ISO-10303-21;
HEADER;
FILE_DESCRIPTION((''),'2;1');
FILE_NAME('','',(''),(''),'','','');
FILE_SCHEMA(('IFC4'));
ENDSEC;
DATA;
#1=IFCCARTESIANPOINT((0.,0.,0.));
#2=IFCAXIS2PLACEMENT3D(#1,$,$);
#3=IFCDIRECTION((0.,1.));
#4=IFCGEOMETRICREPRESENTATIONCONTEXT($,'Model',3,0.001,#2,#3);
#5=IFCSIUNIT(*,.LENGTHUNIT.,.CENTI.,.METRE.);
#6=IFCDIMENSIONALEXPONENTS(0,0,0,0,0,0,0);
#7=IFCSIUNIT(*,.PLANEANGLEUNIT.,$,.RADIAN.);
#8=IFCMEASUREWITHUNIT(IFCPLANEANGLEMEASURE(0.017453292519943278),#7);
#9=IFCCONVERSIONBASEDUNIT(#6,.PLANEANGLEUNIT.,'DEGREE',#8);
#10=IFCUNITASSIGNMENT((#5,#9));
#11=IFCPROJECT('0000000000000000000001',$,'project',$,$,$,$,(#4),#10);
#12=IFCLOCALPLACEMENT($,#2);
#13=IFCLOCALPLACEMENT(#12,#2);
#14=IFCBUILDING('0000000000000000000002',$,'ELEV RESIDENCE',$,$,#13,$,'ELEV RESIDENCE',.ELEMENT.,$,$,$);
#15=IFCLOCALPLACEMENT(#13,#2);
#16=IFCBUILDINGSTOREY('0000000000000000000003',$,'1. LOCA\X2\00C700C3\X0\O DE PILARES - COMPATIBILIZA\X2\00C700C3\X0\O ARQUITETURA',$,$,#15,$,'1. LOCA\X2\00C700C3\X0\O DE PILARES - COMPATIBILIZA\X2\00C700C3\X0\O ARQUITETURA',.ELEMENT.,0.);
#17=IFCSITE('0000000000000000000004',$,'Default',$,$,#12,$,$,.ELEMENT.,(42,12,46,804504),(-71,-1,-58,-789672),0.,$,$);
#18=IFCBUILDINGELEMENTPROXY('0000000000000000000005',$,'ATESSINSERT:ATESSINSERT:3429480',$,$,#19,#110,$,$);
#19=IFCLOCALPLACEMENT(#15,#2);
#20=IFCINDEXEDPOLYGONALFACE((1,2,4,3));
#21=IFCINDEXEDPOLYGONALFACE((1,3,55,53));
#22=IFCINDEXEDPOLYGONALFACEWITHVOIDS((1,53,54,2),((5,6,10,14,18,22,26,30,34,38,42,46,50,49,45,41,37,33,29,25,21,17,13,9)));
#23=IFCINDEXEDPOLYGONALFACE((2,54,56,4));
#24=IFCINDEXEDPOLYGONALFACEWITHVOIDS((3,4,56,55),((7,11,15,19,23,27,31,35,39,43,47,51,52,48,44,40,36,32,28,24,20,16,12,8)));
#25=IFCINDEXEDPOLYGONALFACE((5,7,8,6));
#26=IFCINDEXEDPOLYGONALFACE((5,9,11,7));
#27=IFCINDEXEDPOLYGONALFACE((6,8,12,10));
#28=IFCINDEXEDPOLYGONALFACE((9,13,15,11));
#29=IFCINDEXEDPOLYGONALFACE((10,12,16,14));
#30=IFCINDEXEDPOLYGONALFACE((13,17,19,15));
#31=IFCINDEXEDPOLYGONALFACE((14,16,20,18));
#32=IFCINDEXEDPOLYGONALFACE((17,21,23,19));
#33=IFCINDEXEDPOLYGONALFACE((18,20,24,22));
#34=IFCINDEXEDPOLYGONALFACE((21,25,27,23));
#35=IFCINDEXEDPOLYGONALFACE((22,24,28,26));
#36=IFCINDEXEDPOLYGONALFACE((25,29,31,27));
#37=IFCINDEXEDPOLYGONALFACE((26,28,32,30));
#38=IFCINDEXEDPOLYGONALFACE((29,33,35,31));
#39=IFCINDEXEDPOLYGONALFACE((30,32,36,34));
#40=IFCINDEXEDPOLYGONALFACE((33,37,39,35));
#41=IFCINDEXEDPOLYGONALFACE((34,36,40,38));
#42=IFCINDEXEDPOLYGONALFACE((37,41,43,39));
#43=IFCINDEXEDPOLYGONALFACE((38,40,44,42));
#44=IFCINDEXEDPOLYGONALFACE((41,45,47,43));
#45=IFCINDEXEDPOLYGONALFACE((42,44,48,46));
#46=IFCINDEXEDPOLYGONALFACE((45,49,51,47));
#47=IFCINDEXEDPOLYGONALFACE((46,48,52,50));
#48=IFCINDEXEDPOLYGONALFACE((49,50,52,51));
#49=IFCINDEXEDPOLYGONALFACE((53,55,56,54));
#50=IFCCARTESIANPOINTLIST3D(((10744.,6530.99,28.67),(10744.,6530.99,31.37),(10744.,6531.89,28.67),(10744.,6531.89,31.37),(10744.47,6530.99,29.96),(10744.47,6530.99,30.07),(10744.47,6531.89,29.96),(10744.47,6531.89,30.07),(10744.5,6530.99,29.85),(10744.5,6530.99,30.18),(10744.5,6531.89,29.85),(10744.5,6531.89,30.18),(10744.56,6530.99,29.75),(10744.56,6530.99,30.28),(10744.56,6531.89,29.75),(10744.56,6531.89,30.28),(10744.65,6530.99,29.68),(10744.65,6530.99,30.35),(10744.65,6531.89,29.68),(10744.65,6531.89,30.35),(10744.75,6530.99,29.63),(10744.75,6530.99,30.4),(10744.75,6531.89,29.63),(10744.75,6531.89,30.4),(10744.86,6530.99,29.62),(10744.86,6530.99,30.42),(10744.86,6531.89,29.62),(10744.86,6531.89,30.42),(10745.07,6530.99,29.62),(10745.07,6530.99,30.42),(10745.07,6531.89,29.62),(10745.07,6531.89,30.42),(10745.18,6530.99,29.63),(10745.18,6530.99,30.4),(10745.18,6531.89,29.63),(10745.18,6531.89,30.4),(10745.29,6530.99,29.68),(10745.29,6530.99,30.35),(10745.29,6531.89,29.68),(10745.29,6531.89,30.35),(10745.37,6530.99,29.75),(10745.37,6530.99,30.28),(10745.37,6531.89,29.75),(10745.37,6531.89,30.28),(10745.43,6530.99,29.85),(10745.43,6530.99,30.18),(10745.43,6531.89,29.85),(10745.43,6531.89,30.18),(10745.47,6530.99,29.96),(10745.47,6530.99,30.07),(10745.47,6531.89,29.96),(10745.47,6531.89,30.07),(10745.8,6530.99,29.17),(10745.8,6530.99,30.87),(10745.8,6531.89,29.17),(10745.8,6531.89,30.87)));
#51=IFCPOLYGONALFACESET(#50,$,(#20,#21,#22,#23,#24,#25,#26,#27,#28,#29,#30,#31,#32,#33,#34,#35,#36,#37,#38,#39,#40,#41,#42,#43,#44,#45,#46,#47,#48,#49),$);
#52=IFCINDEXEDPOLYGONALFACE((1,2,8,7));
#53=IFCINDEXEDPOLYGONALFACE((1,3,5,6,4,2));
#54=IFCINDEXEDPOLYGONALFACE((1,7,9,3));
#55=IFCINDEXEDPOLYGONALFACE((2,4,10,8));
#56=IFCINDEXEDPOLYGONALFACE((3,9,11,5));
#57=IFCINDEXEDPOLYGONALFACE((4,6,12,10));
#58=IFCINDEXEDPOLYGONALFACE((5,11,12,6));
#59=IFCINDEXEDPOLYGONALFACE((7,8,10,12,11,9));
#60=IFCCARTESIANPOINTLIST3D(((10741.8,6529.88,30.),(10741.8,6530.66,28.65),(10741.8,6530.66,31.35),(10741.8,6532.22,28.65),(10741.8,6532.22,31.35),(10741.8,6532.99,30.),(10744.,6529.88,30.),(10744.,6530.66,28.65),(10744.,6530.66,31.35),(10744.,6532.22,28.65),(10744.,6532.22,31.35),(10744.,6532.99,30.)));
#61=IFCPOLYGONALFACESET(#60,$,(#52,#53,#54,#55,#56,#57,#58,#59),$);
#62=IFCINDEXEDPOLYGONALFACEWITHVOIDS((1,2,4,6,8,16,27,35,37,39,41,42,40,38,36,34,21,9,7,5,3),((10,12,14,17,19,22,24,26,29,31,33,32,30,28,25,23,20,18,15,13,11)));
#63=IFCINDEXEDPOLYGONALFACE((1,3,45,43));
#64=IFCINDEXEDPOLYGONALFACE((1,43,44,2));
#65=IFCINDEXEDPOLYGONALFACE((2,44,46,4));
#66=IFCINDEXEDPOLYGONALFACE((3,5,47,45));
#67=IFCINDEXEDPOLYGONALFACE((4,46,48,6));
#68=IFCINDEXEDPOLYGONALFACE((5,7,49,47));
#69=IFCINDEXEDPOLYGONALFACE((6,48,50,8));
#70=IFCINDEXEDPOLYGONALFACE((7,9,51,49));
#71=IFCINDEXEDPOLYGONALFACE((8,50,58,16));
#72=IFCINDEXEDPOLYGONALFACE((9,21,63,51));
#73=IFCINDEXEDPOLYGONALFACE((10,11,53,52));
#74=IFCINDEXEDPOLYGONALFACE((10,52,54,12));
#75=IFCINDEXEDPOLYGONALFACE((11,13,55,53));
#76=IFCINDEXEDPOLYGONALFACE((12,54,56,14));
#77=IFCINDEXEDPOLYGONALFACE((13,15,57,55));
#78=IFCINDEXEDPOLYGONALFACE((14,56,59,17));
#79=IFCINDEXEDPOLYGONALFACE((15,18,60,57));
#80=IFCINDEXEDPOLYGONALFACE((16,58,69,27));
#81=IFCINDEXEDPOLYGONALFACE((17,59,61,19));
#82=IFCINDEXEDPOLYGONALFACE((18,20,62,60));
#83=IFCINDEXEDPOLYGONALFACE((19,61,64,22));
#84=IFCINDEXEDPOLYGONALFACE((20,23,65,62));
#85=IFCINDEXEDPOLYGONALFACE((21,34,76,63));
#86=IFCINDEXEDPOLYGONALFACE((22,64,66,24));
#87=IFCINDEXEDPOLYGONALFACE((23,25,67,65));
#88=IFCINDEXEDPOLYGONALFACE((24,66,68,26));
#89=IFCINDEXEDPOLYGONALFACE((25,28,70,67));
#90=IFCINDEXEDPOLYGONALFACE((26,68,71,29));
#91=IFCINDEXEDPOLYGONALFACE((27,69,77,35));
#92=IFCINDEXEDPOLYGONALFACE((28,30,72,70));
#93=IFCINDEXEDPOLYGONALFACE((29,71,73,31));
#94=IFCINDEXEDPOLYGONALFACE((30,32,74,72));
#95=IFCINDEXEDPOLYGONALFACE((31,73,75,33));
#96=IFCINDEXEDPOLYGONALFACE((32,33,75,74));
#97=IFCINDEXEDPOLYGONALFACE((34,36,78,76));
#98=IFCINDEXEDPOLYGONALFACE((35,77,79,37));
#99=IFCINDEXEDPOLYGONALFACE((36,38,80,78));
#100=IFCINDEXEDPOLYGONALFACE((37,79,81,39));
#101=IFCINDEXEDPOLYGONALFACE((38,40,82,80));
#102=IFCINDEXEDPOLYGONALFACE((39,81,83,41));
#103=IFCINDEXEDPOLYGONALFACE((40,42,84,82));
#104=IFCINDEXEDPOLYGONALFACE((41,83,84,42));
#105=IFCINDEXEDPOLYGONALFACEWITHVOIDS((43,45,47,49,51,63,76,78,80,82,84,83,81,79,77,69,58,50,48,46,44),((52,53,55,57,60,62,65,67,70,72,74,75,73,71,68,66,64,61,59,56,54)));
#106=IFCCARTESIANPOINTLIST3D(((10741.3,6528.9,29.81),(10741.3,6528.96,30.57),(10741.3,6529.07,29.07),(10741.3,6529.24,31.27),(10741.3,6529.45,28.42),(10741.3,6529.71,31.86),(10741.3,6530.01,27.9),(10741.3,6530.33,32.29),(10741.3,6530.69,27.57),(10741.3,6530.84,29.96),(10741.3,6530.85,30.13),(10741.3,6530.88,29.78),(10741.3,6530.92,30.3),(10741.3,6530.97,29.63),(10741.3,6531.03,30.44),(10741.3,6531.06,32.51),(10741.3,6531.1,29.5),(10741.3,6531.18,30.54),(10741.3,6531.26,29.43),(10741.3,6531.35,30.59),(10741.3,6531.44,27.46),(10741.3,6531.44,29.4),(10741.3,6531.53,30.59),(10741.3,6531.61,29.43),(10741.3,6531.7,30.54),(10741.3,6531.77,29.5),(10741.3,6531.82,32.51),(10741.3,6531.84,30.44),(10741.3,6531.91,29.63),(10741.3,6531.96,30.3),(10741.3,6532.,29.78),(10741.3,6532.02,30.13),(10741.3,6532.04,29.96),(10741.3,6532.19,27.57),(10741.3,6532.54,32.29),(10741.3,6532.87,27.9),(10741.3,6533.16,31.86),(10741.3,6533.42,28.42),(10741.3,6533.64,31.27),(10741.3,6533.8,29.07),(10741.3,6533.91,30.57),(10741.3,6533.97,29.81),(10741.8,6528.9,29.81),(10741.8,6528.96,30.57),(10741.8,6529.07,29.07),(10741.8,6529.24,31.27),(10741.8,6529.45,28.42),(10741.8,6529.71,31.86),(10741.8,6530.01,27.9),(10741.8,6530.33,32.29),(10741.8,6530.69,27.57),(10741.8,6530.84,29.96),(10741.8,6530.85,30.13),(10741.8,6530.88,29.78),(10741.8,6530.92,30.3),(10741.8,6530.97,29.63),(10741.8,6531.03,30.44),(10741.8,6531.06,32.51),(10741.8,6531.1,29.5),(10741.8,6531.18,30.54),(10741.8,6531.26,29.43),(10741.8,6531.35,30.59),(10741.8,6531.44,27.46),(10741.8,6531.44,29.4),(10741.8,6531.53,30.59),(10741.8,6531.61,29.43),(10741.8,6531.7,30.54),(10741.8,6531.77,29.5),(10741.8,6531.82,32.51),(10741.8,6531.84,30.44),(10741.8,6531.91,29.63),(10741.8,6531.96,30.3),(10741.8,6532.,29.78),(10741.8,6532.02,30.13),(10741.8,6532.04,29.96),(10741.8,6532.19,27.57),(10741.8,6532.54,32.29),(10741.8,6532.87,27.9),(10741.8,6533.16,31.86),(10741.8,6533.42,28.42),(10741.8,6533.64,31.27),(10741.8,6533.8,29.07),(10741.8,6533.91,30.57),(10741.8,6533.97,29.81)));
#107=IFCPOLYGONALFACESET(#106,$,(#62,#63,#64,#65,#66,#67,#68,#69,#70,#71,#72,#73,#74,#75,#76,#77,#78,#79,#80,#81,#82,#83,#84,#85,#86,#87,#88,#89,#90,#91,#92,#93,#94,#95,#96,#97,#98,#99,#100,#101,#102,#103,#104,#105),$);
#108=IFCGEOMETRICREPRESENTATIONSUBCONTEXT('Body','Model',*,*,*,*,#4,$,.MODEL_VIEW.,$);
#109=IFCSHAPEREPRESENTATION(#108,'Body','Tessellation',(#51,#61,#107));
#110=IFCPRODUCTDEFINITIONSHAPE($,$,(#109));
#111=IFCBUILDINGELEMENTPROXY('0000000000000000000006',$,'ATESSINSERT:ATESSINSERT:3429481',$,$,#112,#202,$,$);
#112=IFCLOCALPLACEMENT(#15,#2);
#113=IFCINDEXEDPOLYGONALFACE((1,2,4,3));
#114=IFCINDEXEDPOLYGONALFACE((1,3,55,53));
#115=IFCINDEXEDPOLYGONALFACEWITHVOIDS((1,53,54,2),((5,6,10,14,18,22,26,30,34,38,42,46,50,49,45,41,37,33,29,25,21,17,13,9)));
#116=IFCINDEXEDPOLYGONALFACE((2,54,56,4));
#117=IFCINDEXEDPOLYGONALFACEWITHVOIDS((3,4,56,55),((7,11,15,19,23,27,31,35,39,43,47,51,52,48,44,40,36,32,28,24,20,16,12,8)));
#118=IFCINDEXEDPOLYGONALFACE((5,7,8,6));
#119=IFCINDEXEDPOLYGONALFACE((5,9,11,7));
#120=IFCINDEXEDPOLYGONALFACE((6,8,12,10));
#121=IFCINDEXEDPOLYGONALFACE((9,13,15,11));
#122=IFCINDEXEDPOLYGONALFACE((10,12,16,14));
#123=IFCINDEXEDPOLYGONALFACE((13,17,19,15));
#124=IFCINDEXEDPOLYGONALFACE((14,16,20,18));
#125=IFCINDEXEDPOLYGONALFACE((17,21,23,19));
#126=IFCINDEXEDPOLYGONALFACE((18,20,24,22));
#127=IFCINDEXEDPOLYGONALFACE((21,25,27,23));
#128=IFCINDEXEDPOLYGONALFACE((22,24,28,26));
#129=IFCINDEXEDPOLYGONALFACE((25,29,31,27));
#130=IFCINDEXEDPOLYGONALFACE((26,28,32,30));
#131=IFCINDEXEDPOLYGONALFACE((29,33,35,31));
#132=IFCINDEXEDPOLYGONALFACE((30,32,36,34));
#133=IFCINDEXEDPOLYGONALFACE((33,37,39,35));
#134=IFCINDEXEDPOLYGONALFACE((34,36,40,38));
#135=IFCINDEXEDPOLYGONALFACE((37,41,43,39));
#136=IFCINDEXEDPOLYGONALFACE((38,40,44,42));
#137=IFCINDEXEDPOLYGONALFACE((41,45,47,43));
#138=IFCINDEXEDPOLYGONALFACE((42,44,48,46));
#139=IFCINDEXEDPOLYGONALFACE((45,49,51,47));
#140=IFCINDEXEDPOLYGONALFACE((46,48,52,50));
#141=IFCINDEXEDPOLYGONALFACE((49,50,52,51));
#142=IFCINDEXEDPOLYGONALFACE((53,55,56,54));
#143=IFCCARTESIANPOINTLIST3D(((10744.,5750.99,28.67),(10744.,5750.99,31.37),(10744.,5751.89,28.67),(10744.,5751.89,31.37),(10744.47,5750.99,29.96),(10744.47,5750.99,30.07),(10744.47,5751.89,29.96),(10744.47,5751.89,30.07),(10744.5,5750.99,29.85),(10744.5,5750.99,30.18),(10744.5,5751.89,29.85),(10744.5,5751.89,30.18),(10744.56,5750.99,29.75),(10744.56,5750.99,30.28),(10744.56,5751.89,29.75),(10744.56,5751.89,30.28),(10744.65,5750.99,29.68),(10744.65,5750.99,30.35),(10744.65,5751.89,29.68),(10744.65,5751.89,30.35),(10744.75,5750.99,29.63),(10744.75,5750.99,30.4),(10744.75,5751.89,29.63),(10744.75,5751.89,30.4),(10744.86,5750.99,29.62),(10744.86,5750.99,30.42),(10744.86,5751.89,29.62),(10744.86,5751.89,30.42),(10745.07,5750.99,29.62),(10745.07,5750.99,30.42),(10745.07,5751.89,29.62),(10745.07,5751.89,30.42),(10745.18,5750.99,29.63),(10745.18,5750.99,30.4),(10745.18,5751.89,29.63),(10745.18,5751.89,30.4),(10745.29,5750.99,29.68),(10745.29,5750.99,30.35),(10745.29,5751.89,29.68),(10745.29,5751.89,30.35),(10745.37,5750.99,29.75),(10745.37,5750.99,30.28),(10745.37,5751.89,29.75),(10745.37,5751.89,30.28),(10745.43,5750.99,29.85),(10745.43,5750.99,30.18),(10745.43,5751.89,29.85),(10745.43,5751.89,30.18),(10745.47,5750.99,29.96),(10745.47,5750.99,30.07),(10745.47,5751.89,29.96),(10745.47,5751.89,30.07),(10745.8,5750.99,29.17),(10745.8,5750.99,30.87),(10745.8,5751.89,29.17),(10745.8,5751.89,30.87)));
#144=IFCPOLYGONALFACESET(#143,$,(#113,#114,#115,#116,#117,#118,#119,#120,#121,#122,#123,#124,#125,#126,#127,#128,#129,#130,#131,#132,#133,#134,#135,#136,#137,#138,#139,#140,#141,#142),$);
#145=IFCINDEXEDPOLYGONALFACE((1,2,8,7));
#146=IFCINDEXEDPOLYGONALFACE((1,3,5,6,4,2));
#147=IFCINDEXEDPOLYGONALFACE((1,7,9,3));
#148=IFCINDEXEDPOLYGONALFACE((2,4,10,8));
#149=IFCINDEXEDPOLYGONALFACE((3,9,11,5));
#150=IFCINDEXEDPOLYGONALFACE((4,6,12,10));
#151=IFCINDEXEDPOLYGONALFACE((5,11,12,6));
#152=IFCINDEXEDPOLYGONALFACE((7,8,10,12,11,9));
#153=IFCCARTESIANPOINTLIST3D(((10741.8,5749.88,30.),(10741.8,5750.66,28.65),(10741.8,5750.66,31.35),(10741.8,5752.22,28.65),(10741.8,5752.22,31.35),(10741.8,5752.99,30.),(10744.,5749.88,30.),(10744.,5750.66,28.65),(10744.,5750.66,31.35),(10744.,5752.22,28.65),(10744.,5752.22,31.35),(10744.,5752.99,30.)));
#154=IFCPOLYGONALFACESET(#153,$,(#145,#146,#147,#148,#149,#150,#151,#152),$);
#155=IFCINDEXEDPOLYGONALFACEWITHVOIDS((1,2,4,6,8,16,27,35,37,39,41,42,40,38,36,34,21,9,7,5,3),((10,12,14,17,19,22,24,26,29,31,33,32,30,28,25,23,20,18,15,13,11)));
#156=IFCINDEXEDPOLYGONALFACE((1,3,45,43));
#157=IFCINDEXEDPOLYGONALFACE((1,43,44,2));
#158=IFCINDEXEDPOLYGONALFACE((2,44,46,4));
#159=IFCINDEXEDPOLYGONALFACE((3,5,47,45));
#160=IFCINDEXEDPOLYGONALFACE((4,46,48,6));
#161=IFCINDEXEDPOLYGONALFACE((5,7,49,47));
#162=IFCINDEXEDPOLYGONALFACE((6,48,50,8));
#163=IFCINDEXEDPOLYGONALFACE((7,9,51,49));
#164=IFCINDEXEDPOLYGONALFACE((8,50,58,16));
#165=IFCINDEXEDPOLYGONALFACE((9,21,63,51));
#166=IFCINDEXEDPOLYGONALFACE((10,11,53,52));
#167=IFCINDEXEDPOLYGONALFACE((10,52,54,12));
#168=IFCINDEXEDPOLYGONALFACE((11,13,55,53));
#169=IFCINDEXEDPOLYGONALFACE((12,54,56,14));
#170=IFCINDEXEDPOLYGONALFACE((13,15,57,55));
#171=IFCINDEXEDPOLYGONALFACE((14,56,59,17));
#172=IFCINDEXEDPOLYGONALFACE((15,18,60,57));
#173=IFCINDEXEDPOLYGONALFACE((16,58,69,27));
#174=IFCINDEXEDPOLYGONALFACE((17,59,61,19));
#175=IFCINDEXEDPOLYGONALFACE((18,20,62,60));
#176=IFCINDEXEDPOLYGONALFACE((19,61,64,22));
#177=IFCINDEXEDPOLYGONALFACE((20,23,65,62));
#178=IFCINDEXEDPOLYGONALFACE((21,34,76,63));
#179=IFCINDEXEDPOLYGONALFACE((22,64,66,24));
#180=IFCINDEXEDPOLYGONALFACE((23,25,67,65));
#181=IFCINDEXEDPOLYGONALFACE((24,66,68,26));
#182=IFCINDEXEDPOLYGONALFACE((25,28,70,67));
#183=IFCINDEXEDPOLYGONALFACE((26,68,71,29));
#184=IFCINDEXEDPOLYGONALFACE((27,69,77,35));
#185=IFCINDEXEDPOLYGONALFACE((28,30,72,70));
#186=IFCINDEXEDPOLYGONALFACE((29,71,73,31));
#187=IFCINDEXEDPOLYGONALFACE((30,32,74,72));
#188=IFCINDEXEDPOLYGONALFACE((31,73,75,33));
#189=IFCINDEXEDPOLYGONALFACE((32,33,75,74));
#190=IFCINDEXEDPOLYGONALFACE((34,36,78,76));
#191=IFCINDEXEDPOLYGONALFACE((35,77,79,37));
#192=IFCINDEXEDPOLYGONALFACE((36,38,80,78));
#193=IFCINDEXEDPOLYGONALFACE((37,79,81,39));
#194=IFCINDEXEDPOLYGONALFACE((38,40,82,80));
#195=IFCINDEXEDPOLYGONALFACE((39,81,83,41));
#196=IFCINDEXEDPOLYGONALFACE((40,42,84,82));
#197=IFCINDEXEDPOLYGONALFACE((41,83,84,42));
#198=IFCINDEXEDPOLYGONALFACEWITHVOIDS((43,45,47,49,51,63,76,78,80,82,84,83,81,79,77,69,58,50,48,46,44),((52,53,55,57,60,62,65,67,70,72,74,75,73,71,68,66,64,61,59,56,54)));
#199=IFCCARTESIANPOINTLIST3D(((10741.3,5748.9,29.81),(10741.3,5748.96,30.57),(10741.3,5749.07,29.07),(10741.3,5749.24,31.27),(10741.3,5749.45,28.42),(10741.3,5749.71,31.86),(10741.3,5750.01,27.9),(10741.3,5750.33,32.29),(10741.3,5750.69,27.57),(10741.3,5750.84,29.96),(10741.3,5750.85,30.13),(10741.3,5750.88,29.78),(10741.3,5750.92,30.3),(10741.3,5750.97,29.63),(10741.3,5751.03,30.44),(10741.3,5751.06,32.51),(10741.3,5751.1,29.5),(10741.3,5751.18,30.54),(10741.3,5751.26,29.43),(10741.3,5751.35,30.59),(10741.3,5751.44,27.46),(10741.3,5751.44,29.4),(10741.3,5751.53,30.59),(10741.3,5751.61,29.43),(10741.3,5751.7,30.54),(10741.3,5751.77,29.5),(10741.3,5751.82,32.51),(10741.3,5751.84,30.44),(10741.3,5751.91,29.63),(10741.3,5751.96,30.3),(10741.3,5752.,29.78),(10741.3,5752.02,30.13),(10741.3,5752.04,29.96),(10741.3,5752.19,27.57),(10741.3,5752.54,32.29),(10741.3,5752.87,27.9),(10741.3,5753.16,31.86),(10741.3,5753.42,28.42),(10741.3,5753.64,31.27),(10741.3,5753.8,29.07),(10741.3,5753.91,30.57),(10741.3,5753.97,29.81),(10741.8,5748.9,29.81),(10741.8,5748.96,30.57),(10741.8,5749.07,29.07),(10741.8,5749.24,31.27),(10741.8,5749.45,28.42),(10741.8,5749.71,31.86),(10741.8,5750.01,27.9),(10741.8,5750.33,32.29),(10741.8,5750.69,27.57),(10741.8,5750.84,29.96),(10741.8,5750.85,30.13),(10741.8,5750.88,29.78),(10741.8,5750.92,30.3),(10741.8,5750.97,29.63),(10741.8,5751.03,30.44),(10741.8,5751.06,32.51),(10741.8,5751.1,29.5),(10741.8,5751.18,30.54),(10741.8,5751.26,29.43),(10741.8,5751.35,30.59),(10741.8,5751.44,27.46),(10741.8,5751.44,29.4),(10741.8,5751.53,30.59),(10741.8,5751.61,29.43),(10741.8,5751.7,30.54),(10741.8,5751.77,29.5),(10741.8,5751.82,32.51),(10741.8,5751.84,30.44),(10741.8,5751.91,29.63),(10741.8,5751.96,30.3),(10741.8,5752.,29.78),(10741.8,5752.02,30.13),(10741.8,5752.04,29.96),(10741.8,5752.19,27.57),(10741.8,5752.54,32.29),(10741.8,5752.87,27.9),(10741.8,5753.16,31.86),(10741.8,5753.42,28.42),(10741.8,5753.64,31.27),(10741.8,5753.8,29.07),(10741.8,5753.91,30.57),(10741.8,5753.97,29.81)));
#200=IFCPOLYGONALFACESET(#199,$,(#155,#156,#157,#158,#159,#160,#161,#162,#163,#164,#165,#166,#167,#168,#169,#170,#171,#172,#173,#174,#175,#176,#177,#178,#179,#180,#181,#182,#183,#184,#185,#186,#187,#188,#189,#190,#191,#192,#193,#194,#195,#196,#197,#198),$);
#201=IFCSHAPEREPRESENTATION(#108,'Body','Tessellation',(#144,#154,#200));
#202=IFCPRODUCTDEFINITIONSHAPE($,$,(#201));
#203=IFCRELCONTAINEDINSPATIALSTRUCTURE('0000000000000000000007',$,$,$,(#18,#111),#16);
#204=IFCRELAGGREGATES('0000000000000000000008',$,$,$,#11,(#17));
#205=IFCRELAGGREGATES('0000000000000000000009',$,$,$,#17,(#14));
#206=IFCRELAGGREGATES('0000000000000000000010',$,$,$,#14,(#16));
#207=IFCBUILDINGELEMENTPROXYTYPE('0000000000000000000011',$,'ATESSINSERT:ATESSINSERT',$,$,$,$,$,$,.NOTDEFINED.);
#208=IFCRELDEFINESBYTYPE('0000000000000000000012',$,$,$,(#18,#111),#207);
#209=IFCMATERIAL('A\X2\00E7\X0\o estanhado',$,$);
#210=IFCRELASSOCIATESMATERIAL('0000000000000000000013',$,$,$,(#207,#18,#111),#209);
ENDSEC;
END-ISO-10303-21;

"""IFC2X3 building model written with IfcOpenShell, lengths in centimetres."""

from ifc_helpers import new_model, entity, si_unit, converted_unit, direction, frame, frame_2d, origin, place, context, subcontext, project, spatial, polyline, circle_curve, parameter, trimmed, segment, composite_curve, hollow_circle, outline, extrude, source, transform, mapped, material, type_object, type_shapes, element, save


model = new_model("IFC2X3")

# Units and contexts
model_context = context("Model", 3, precision=0.001, world=origin(), true_north=direction((0.0, 1.0)))
body_context = subcontext(model_context, "Body", "Model", "MODEL_VIEW")
ifc_project = project(units=[si_unit("LENGTHUNIT", "METRE", prefix="CENTI"), converted_unit("PLANEANGLEUNIT", "DEGREE", entity("IfcPlaneAngleMeasure", 0.017453292519943278), si_unit("PLANEANGLEUNIT", "RADIAN"), dimensions=[0, 0, 0, 0, 0, 0, 0])], contexts=[model_context])

# Site, building, storey
site_placement = place(None, origin())
site = spatial("IfcSite", under=ifc_project, at=site_placement, Name="Default", CompositionType="ELEMENT", RefLatitude=(42, 12, 46, 804504), RefLongitude=(-71, -1, -58, -789672), RefElevation=0.0)
building_placement = place(site_placement, origin())
building = spatial("IfcBuilding", under=site, at=building_placement, Name="ELEV RESIDENCE", LongName="ELEV RESIDENCE", CompositionType="ELEMENT")
storey_placement = place(building_placement, origin())
storey = spatial("IfcBuildingStorey", under=building, at=storey_placement, Name="1. LOCAÇÃO DE PILARES - COMPATIBILIZAÇÃO ARQUITETURA", LongName="1. LOCAÇÃO DE PILARES - COMPATIBILIZAÇÃO ARQUITETURA", CompositionType="ELEMENT", Elevation=0.0)

# Building element proxies
ifc_material_1 = material(Name="Aço estanhado")
building_element_proxy_type_1 = type_object("IfcBuildingElementProxyType", Name="ATESSINSERT:ATESSINSERT", PredefinedType="NOTDEFINED", material=ifc_material_1)
shared_shape_1 = source(origin(), body_context, "Body", "SweptSolid", [
    extrude(outline(polyline([(-1.35, -0.9), (1.35, -0.9), (0.85, 0.9), (-0.85, 0.9), (-1.35, -0.9)]), holes=[composite_curve([segment(trimmed(circle_curve(frame_2d((0.0, 0.17), x_axis=(1.0, 0.0)), 0.4), [parameter(0.0)], [parameter(180.0)], True, "PARAMETER"), False, "CONTINUOUS"), segment(polyline([(0.4, 0.17), (0.4, -0.03)]), True, "CONTINUOUS"), segment(trimmed(circle_curve(frame_2d((0.0, -0.03), x_axis=(1.0, 0.0)), 0.4), [parameter(180.0)], [parameter(0.0)], True, "PARAMETER"), False, "CONTINUOUS"), segment(polyline([(-0.4, -0.03), (-0.4, 0.17)]), True, "CONTINUOUS")], self_intersect=False)]), frame((-1.4, -0.45, 30.02), z_axis=(0.0, 1.0, 0.0), x_axis=(0.0, 0.0, 1.0)), (0.0, 0.0, 1.0), 0.9),
    extrude(outline(polyline([(-0.78, -1.35), (0.78, -1.35), (1.56, 0.0), (0.78, 1.35), (-0.78, 1.35), (-1.56, 0.0), (-0.78, -1.35)])), frame((-4.5, 0.0, 30.0), z_axis=(1.0, 0.0, 0.0), x_axis=(0.0, 1.0, 0.0)), (0.0, 0.0, 1.0), 2.2),
    extrude(hollow_circle(Radius=2.54, WallThickness=1.94, at=frame_2d((0.0, 0.0), x_axis=(1.0, 0.0))), frame((-5.0, 0.0, 30.0), z_axis=(1.0, 0.0, 0.0), x_axis=(0.0, 0.0, -1.0)), (0.0, 0.0, 1.0), 0.5),
])
type_shapes(building_element_proxy_type_1, [shared_shape_1])
for number, where, name in (
    (1, (10746.3, 6531.44, 0.0), "ATESSINSERT:ATESSINSERT:3429480"),
    (2, (10746.3, 5751.44, 0.0), "ATESSINSERT:ATESSINSERT:3429481"),
):
    element("IfcBuildingElementProxy", number, at=place(storey_placement, frame(where)), inside=storey, type_object=building_element_proxy_type_1, material=ifc_material_1, Name=name, context=body_context, shape_type="MappedRepresentation", body=[
        mapped(shared_shape_1, transform((0.0, 0.0, 0.0), scale=1.0)),
    ])

save(model, "model.ifc")
